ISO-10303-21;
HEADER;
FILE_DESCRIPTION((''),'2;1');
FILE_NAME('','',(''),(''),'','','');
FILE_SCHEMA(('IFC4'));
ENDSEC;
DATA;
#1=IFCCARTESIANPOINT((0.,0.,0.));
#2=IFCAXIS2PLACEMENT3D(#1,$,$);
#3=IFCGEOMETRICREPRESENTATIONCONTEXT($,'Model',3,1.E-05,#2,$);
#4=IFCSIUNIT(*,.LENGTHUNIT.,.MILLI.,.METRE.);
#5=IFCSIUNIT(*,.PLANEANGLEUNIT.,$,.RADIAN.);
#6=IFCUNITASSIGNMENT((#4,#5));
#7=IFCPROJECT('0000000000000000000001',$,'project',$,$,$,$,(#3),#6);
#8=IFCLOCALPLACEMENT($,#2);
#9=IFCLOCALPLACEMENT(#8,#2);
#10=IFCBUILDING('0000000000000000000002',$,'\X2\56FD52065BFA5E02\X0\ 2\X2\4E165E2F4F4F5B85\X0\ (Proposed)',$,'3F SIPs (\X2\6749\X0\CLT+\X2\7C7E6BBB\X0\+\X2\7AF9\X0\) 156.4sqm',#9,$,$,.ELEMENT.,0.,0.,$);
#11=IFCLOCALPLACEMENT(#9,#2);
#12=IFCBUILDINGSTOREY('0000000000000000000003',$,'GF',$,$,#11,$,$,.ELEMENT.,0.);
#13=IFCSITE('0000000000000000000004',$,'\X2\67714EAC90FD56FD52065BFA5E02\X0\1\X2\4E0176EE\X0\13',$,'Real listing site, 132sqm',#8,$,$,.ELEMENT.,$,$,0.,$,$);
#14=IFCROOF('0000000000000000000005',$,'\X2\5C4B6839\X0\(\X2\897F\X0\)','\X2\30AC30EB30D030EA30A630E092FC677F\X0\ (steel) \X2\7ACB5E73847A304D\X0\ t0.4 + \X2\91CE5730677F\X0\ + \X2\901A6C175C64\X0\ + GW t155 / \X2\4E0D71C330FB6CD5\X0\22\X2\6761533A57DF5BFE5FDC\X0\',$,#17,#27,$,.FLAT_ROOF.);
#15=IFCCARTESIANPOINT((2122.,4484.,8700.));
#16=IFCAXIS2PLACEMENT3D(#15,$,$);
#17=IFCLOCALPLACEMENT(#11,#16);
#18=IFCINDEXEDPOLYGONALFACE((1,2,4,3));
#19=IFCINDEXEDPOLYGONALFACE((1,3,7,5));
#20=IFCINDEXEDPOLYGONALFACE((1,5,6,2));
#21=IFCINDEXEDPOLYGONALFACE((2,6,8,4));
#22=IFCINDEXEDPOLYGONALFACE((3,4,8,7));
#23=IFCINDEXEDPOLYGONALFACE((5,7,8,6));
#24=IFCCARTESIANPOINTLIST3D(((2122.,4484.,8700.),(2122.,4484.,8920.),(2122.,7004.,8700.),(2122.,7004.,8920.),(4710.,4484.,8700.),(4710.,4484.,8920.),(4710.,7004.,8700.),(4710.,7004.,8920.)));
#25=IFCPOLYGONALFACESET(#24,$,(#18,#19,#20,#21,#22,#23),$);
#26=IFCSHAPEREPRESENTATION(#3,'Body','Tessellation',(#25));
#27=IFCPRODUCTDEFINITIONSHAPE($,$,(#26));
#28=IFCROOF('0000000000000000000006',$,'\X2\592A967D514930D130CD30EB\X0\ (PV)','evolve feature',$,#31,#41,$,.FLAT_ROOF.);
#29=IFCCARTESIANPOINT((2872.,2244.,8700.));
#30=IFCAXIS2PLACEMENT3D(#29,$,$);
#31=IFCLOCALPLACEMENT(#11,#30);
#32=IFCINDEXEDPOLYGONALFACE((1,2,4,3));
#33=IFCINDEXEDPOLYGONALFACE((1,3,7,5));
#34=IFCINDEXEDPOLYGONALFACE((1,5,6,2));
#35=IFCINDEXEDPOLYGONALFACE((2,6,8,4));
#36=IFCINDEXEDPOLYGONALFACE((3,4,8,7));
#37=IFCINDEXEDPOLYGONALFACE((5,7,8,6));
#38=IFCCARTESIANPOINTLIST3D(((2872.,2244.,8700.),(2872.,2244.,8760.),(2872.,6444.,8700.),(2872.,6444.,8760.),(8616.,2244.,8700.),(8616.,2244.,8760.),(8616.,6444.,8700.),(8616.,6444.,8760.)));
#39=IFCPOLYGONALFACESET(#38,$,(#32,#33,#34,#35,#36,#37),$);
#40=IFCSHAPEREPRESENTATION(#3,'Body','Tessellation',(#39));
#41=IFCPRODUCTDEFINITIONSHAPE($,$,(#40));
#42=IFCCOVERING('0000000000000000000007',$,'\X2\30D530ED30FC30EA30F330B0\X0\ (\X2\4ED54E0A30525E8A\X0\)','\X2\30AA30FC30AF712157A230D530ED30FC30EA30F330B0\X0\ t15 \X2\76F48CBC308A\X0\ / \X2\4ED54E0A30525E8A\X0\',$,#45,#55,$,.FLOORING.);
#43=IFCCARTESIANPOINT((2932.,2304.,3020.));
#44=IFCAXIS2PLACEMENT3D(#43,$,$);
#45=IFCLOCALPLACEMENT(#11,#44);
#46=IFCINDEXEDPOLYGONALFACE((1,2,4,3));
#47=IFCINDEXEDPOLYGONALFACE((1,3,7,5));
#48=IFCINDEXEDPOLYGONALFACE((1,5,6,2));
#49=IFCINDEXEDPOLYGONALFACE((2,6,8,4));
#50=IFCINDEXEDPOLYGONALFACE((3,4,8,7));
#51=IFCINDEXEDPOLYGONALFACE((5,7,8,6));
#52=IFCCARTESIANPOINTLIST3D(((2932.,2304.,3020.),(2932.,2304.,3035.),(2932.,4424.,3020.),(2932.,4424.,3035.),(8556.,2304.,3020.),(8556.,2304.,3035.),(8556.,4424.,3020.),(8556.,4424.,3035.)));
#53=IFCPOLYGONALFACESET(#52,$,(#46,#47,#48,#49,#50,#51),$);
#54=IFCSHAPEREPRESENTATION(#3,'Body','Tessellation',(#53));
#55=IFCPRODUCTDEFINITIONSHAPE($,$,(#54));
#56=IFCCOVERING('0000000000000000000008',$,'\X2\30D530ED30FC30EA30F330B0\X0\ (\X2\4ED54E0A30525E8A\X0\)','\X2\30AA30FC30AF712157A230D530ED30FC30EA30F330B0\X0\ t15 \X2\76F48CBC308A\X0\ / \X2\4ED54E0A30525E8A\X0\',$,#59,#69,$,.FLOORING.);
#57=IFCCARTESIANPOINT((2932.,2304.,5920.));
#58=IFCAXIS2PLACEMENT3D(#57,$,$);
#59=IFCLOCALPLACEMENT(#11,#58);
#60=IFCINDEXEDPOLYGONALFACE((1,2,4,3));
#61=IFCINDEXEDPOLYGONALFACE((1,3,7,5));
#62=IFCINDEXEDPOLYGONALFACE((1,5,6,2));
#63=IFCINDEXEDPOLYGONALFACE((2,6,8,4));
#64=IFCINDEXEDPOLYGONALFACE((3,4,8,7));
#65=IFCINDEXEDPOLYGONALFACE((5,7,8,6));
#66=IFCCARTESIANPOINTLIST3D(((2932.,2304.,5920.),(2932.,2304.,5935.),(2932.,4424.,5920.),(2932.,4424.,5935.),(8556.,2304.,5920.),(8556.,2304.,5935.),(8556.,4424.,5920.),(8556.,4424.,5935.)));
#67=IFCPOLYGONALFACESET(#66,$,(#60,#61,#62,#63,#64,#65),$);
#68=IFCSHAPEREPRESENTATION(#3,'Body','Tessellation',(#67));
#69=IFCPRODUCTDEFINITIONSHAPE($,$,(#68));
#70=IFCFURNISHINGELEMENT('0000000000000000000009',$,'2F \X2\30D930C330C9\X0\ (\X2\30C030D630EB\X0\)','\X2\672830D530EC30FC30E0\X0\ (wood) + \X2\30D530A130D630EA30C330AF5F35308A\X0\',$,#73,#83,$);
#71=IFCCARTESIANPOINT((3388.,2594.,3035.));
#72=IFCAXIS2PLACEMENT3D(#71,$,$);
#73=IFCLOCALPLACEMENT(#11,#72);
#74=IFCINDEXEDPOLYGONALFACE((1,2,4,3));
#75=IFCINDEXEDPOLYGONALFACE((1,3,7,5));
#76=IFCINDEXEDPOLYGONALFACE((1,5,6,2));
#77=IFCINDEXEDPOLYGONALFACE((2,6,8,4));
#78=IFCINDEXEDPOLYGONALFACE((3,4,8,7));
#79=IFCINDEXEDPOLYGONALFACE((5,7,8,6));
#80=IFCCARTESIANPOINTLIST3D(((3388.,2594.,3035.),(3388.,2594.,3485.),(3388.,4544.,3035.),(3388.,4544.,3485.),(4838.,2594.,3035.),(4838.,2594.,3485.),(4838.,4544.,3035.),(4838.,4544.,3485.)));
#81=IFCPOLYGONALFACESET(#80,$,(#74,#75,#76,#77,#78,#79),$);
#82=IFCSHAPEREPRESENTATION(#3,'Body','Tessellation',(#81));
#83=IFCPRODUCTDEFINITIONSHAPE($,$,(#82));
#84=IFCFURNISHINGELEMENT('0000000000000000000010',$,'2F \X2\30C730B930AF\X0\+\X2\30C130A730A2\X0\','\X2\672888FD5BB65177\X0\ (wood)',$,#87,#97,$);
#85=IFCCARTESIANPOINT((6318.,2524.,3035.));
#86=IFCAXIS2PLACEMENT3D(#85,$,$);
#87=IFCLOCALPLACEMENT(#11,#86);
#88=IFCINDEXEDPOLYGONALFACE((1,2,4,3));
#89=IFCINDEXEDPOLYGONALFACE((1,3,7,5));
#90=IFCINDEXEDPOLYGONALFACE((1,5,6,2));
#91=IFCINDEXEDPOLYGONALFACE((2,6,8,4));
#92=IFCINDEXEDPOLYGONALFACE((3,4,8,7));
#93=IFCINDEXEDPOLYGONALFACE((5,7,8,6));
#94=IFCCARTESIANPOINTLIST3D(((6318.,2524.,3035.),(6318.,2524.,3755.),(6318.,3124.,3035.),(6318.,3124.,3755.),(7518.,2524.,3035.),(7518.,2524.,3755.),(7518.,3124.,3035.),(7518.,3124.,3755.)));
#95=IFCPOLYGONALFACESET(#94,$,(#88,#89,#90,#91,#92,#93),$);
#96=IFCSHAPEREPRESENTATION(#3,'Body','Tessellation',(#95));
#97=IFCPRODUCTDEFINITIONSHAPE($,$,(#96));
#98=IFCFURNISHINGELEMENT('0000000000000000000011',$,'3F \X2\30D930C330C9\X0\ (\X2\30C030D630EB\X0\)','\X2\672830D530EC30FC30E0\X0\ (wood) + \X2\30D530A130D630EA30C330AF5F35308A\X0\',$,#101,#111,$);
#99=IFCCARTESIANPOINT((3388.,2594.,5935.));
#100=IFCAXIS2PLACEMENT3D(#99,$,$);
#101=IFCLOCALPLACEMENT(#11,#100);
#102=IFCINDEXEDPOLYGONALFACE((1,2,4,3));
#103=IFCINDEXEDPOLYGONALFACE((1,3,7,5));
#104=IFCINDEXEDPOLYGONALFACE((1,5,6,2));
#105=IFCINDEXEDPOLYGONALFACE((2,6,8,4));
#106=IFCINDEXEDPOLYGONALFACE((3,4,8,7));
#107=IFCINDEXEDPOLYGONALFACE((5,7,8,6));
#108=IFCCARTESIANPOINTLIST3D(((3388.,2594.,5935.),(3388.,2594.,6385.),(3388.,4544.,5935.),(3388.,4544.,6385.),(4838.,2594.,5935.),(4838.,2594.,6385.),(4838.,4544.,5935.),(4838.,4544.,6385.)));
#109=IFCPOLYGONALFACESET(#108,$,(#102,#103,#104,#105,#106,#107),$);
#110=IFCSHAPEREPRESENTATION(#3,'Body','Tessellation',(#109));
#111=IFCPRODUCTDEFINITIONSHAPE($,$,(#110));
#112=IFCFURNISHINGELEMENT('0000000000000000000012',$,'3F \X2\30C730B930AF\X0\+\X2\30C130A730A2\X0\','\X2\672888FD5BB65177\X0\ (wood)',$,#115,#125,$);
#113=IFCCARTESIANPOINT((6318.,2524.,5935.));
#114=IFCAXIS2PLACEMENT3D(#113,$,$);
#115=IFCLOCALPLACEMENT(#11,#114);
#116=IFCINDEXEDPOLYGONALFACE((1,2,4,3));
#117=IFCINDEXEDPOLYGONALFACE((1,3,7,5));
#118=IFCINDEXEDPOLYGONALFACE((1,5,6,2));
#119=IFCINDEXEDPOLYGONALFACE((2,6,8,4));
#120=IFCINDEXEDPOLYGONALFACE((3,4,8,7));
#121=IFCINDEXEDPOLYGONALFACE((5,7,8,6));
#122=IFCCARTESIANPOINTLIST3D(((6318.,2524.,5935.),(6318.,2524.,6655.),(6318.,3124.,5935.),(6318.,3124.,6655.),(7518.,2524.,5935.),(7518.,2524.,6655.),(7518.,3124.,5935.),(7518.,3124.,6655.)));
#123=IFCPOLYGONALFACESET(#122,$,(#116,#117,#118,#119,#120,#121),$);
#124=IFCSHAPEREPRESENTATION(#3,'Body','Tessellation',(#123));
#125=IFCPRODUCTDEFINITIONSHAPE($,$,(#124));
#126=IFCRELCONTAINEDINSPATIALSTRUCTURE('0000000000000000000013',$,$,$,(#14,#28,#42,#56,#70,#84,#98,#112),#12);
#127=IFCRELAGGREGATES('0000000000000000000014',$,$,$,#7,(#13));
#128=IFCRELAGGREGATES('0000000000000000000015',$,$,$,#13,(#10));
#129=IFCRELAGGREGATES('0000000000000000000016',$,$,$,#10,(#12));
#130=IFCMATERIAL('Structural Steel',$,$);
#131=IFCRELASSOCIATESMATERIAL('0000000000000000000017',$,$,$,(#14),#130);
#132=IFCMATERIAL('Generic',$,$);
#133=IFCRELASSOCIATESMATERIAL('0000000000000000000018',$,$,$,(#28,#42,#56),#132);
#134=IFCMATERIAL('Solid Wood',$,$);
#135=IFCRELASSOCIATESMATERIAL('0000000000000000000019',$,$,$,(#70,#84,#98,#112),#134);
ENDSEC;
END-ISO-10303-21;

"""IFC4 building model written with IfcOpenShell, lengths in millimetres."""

from ifc_helpers import new_model, si_unit, frame, frame_2d, origin, place, context, project, spatial, rectangle, extrude, material, element, save


model = new_model("IFC4")

# Units and contexts
model_context = context("Model", 3, precision=1e-05, world=origin())
ifc_project = project(units=[si_unit("LENGTHUNIT", "METRE", prefix="MILLI"), si_unit("PLANEANGLEUNIT", "RADIAN")], contexts=[model_context])

# Site, building, storey
site_placement = place(None, origin())
site = spatial("IfcSite", under=ifc_project, at=site_placement, Name="東京都国分寺市1丁目13", ObjectType="Real listing site, 132sqm", CompositionType="ELEMENT", RefElevation=0.0)
building_placement = place(site_placement, origin())
building = spatial("IfcBuilding", under=site, at=building_placement, Name="国分寺市 2世帯住宅 (Proposed)", ObjectType="3F SIPs (杉CLT+籾殻+竹) 156.4sqm", CompositionType="ELEMENT", ElevationOfRefHeight=0.0, ElevationOfTerrain=0.0)
storey_placement = place(building_placement, origin())
storey = spatial("IfcBuildingStorey", under=building, at=storey_placement, Name="GF", CompositionType="ELEMENT", Elevation=0.0)

# Shared definitions
ifc_material_1 = material(Name="Solid Wood")

# Roofs
ifc_material_2 = material(Name="Structural Steel")
roof_1_placement = place(storey_placement, frame((2122.0, 4484.0, 8700.0)))
element("IfcRoof", 1, at=roof_1_placement, inside=storey, material=ifc_material_2, Name="屋根(西)", Description="ガルバリウム鋼板 (steel) 立平葺き t0.4 + 野地板 + 通気層 + GW t155 / 不燃・法22条区域対応", PredefinedType="FLAT_ROOF", context=model_context, shape_type="SweptSolid", body=[
    extrude(rectangle(XDim=2588.0, YDim=2520.0, at=frame_2d((1294.0, 1260.0))), frame((2122.0, 4484.0, 8700.0)), (0.0, 0.0, 1.0), 220.0),
])
ifc_material_3 = material(Name="Generic")
roof_2_placement = place(storey_placement, frame((2872.0, 2244.0, 8700.0)))
element("IfcRoof", 2, at=roof_2_placement, inside=storey, material=ifc_material_3, Name="太陽光パネル (PV)", Description="evolve feature", PredefinedType="FLAT_ROOF", context=model_context, shape_type="SweptSolid", body=[
    extrude(rectangle(XDim=5744.0, YDim=4200.0, at=frame_2d((2872.0, 2100.0))), frame((2872.0, 2244.0, 8700.0)), (0.0, 0.0, 1.0), 60.0),
])

# Coverings
covering_1_placement = place(storey_placement, frame((2932.0, 2304.0, 3020.0)))
element("IfcCovering", 3, at=covering_1_placement, inside=storey, material=ifc_material_3, Name="フローリング (仕上げ床)", Description="オーク無垢フローリング t15 直貼り / 仕上げ床", PredefinedType="FLOORING", context=model_context, shape_type="SweptSolid", body=[
    extrude(rectangle(XDim=5624.0, YDim=2120.0, at=frame_2d((2812.0, 1060.0))), frame((2932.0, 2304.0, 3020.0)), (0.0, 0.0, 1.0), 15.0),
])
covering_2_placement = place(storey_placement, frame((2932.0, 2304.0, 5920.0)))
element("IfcCovering", 4, at=covering_2_placement, inside=storey, material=ifc_material_3, Name="フローリング (仕上げ床)", Description="オーク無垢フローリング t15 直貼り / 仕上げ床", PredefinedType="FLOORING", context=model_context, shape_type="SweptSolid", body=[
    extrude(rectangle(XDim=5624.0, YDim=2120.0, at=frame_2d((2812.0, 1060.0))), frame((2932.0, 2304.0, 5920.0)), (0.0, 0.0, 1.0), 15.0),
])

# Furnishing elements
furnishing_1_placement = place(storey_placement, frame((3388.0, 2594.0, 3035.0)))
element("IfcFurnishingElement", 5, at=furnishing_1_placement, inside=storey, material=ifc_material_1, Name="2F ベッド (ダブル)", Description="木フレーム (wood) + ファブリック張り", context=model_context, shape_type="SweptSolid", body=[
    extrude(rectangle(XDim=1450.0, YDim=1950.0, at=frame_2d((725.0, 975.0))), frame((3388.0, 2594.0, 3035.0)), (0.0, 0.0, 1.0), 450.0),
])
furnishing_2_placement = place(storey_placement, frame((6318.0, 2524.0, 3035.0)))
element("IfcFurnishingElement", 6, at=furnishing_2_placement, inside=storey, material=ifc_material_1, Name="2F デスク+チェア", Description="木製家具 (wood)", context=model_context, shape_type="SweptSolid", body=[
    extrude(rectangle(XDim=1200.0, YDim=600.0, at=frame_2d((600.0, 300.0))), frame((6318.0, 2524.0, 3035.0)), (0.0, 0.0, 1.0), 720.0),
])
furnishing_3_placement = place(storey_placement, frame((3388.0, 2594.0, 5935.0)))
element("IfcFurnishingElement", 7, at=furnishing_3_placement, inside=storey, material=ifc_material_1, Name="3F ベッド (ダブル)", Description="木フレーム (wood) + ファブリック張り", context=model_context, shape_type="SweptSolid", body=[
    extrude(rectangle(XDim=1450.0, YDim=1950.0, at=frame_2d((725.0, 975.0))), frame((3388.0, 2594.0, 5935.0)), (0.0, 0.0, 1.0), 450.0),
])
furnishing_4_placement = place(storey_placement, frame((6318.0, 2524.0, 5935.0)))
element("IfcFurnishingElement", 8, at=furnishing_4_placement, inside=storey, material=ifc_material_1, Name="3F デスク+チェア", Description="木製家具 (wood)", context=model_context, shape_type="SweptSolid", body=[
    extrude(rectangle(XDim=1200.0, YDim=600.0, at=frame_2d((600.0, 300.0))), frame((6318.0, 2524.0, 5935.0)), (0.0, 0.0, 1.0), 720.0),
])

save(model, "model.ifc")
